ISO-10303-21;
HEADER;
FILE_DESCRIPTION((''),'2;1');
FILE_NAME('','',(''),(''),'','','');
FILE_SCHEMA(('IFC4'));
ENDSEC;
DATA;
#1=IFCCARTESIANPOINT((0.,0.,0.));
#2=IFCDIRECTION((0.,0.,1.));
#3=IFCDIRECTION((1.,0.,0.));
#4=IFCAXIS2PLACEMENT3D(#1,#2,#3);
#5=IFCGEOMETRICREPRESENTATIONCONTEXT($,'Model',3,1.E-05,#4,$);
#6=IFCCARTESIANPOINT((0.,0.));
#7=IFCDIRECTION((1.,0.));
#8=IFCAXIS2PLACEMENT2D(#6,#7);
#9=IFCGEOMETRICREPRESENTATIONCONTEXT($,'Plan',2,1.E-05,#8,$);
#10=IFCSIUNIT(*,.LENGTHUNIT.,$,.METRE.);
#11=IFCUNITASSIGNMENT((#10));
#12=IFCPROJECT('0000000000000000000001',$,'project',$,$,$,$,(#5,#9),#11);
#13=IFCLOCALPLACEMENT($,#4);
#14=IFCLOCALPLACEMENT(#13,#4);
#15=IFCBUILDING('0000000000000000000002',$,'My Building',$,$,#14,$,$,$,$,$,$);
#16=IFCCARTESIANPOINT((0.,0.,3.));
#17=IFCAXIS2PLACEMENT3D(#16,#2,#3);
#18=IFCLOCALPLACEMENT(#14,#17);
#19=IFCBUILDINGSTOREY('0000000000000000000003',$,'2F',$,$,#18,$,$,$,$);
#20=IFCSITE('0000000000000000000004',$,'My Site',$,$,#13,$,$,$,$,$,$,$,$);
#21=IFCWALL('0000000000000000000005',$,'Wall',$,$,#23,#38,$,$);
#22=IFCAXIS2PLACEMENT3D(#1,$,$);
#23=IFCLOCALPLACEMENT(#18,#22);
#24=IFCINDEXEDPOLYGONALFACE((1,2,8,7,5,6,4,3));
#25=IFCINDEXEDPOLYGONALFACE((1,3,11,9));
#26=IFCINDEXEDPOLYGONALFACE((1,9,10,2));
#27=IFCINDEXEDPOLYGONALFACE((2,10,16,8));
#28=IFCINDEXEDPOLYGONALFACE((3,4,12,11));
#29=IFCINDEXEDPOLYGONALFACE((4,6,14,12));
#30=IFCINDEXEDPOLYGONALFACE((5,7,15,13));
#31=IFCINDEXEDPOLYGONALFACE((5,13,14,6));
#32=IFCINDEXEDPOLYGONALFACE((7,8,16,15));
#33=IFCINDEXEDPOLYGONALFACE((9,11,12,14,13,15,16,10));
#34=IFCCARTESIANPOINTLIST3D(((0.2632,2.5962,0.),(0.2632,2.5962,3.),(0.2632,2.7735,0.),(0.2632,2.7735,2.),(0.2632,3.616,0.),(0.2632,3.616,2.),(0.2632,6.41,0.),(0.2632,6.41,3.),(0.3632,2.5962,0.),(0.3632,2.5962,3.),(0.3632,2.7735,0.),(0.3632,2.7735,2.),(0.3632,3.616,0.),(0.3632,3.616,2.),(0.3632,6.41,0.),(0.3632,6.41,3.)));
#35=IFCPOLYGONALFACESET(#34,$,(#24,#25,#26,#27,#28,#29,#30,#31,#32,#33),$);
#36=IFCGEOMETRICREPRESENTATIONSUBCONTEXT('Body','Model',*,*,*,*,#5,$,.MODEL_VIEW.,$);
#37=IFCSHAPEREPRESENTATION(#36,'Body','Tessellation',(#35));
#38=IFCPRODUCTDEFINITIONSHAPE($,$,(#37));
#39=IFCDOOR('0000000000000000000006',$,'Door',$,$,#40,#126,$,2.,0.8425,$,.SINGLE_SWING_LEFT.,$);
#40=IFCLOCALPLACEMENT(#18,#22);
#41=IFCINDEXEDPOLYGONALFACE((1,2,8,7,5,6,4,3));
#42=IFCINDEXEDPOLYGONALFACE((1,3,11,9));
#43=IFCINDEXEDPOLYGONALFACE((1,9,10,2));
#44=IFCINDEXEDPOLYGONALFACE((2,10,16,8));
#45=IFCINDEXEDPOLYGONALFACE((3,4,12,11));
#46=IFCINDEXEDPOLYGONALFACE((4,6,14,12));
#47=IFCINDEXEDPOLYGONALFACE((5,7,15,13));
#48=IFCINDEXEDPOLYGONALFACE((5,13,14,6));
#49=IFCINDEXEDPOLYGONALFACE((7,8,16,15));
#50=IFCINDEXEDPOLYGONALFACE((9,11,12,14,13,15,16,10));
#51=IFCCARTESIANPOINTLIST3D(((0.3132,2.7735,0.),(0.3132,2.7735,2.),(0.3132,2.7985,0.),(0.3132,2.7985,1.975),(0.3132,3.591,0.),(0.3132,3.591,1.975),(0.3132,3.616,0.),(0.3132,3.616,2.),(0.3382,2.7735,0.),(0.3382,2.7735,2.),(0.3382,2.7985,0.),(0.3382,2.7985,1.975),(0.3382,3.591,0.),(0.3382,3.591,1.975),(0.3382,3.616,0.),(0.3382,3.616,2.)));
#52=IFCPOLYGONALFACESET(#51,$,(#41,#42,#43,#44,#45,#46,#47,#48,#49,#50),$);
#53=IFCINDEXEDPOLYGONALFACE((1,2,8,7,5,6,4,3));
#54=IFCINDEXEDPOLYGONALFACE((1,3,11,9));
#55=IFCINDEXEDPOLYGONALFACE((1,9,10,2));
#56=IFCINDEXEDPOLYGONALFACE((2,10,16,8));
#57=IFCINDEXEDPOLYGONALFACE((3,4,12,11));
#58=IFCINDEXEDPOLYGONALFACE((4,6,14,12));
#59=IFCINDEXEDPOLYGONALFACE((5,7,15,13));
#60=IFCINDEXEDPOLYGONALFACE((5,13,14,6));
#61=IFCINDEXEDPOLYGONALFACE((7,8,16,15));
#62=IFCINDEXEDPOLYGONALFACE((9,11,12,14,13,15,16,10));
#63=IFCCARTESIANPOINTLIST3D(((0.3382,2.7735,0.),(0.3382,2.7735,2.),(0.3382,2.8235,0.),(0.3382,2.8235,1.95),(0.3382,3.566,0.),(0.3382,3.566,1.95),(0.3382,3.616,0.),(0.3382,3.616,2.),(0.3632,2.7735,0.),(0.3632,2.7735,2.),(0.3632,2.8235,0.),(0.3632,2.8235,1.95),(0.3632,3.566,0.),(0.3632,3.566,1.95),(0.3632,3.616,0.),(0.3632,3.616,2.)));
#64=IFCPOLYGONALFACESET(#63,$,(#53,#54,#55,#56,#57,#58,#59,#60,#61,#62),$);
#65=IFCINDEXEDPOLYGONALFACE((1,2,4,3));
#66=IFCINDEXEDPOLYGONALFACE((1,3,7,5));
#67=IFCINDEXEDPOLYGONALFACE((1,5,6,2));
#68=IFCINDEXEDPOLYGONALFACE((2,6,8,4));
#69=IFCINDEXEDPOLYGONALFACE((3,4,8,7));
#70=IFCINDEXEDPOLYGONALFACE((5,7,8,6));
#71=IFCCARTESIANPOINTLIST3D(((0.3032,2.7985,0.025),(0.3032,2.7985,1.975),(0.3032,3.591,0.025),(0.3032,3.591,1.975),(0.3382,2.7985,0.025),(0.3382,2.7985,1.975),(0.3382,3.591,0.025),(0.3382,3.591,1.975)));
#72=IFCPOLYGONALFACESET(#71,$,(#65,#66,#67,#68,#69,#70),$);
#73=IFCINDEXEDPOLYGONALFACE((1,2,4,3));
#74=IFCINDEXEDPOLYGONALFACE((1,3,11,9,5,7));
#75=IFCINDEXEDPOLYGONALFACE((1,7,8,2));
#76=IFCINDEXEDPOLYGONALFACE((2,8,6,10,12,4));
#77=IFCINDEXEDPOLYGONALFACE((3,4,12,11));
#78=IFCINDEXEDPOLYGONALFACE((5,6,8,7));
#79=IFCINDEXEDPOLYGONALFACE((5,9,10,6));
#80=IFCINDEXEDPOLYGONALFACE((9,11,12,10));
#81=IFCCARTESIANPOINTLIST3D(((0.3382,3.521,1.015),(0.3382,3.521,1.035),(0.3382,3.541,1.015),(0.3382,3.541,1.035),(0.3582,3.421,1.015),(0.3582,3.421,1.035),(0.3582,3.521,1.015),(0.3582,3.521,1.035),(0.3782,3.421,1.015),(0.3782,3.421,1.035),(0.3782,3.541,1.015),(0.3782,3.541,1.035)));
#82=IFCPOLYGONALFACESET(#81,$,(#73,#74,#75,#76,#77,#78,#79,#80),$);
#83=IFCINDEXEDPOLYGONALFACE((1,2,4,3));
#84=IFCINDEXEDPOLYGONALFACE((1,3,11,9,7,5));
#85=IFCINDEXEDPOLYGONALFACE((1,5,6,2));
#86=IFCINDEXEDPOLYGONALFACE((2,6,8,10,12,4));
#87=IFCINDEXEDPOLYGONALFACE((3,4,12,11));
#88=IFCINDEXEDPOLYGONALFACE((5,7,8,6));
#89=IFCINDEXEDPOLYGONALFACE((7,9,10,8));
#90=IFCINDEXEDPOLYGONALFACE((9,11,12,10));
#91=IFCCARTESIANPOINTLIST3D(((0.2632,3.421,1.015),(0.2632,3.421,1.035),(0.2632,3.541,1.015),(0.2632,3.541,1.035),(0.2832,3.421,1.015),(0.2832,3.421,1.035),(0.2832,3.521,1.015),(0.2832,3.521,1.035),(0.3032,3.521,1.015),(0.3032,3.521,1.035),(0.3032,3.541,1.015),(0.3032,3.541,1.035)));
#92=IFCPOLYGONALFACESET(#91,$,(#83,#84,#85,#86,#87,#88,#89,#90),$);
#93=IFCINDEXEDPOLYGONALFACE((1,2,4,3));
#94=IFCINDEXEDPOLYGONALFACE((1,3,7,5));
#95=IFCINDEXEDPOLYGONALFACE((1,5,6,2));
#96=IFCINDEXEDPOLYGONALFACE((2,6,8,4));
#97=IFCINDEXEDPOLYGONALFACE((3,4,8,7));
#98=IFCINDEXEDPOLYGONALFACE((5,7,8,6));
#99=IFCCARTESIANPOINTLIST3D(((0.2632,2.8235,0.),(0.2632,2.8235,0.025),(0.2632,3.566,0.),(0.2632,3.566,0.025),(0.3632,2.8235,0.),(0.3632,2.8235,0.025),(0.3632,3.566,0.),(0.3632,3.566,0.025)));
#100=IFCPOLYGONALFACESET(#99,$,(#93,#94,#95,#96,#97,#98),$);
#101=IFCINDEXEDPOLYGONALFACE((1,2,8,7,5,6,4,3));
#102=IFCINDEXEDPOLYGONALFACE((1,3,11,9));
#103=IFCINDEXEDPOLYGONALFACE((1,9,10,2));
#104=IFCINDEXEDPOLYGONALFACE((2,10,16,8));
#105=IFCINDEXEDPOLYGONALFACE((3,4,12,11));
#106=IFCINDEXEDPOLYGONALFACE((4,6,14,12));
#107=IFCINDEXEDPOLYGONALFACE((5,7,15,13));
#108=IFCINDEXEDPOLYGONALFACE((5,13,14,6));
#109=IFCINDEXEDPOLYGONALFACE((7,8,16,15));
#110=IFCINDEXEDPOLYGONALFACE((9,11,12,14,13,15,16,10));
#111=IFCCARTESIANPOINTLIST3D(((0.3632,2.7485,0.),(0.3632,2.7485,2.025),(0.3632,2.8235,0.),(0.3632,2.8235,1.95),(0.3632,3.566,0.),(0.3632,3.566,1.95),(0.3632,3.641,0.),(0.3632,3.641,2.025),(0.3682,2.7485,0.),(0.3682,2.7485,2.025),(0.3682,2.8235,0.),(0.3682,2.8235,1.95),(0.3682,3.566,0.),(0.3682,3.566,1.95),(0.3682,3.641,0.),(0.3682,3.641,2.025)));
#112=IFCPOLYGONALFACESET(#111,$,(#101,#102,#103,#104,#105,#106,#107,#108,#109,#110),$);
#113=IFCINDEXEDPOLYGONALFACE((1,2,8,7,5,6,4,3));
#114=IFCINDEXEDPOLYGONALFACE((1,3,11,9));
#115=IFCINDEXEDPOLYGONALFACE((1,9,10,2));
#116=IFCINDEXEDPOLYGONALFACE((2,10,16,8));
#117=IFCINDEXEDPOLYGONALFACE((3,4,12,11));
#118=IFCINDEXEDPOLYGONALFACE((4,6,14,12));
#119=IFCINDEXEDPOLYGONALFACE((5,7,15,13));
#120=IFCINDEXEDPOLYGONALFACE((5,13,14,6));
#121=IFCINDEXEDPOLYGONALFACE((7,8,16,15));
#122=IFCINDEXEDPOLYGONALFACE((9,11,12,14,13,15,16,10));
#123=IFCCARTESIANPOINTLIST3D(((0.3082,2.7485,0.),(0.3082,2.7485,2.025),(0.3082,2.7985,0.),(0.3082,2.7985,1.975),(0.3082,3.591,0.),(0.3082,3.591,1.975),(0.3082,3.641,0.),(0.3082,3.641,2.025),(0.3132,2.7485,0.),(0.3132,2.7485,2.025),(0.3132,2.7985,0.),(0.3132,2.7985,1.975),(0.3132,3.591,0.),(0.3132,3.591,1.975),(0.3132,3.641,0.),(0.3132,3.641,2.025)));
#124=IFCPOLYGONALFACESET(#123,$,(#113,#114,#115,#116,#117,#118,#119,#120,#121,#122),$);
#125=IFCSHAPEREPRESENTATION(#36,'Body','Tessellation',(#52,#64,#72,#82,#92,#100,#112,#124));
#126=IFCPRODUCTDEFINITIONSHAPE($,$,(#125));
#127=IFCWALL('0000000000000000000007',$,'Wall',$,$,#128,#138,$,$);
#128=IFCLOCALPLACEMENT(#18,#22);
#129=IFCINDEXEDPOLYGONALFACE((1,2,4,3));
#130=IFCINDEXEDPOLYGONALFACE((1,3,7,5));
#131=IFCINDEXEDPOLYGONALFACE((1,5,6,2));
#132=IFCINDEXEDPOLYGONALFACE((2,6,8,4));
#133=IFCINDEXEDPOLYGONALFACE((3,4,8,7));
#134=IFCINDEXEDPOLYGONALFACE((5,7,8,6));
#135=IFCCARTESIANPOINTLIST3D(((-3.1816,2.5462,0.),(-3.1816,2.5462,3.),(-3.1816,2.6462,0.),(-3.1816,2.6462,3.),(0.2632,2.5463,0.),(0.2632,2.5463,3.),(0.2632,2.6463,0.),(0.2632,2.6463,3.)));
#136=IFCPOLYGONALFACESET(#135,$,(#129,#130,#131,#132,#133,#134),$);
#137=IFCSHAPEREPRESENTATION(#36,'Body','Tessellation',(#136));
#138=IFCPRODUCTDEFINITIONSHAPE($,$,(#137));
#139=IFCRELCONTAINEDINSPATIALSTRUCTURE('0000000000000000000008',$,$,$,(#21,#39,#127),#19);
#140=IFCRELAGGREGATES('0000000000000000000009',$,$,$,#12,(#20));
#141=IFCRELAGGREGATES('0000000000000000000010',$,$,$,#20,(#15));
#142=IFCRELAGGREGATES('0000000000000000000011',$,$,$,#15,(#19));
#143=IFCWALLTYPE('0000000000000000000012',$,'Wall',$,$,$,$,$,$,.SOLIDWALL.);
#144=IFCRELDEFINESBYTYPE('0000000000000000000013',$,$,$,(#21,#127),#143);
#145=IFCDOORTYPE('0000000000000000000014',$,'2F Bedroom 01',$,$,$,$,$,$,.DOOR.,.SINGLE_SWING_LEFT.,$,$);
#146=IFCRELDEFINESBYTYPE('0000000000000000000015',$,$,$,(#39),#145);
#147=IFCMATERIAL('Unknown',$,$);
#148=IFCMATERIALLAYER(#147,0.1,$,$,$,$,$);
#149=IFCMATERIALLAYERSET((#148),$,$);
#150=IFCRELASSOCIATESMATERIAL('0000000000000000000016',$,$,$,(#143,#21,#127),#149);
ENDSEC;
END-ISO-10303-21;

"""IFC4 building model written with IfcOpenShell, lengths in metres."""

from ifc_helpers import new_model, entity, si_unit, frame, origin_with_axes, origin_2d_with_axis, place, context, subcontext, project, spatial, line, indexed_curve, outline, extrude, shape, source, transform, mapped, material, layer, layer_set, layer_usage, type_object, type_shapes, element, fill, save


model = new_model("IFC4")

# Units and contexts
model_context = context("Model", 3, precision=1e-05, world=origin_with_axes())
plan_context = context("Plan", 2, precision=1e-05, world=origin_2d_with_axis())
body_context_1 = subcontext(model_context, "Body", "Model", "MODEL_VIEW")
body_context_2 = subcontext(plan_context, "Body", "Plan", "PLAN_VIEW")
ifc_project = project(units=[si_unit("LENGTHUNIT", "METRE")], contexts=[model_context, plan_context])

# Site, building, storey
site_placement = place(None, origin_with_axes())
site = spatial("IfcSite", under=ifc_project, at=site_placement, Name="My Site")
building_placement = place(site_placement, origin_with_axes())
building = spatial("IfcBuilding", under=site, at=building_placement, Name="My Building")
storey_placement = place(building_placement, frame((0.0, 0.0, 3.0), z_axis=(0.0, 0.0, 1.0), x_axis=(1.0, 0.0, 0.0)))
storey = spatial("IfcBuildingStorey", under=building, at=storey_placement, Name="2F")

# Shared definitions
ifc_material_1 = material(Name="Unknown")

# Shared definitions
ifc_layer_1 = layer(ifc_material_1, 0.1)
ifc_layer_set_1 = layer_set([ifc_layer_1])
wall_type = type_object("IfcWallType", Name="Wall", PredefinedType="SOLIDWALL", material=ifc_layer_set_1)

# Wall, opening, door
ifc_layer_usage_1 = layer_usage(ifc_layer_set_1, "AXIS2", "POSITIVE", 0.0)
wall_1_placement = place(storey_placement, frame((0.2632, 6.51, 0.0), z_axis=(0.0, 0.0, 1.0), x_axis=(0.0, -1.0, 0.0)))
wall_1 = element("IfcWall", 1, at=wall_1_placement, inside=storey, type_object=wall_type, material=ifc_layer_usage_1, Name="Wall", context=body_context_1, shape_type="SweptSolid", body=[
    extrude(outline(indexed_curve([(0.1, 0.0), (0.1, 0.1), (3.9137, 0.1), (3.9137, 0.0)], segments=[line(1, 2, 3, 4, 1)])), origin_with_axes(), (0.0, 0.0, 1.0), 3.0),
])
shared_shape_1 = source(origin_with_axes(), body_context_1, "Body", "SweptSolid", [
    extrude(outline(indexed_curve([(0.0, 0.0), (0.8425, 0.0), (0.8425, 2.0), (0.0, 2.0)], segments=[line(1, 2, 3, 4, 1)])), frame((0.0, -0.6, 0.0), z_axis=(0.0, -1.0, 0.0), x_axis=(1.0, 0.0, 0.0)), (0.0, 0.0, -1.0), 1.2),
])
opening_1_placement = place(wall_1_placement, frame((3.7364, 0.1, 0.0), z_axis=(0.0, 0.0, 1.0), x_axis=(-1.0, 0.0, 0.0)))
opening_1 = element("IfcOpeningElement", 2, at=opening_1_placement, cuts=wall_1, PredefinedType="OPENING", context=body_context_1, shape_type="MappedRepresentation", body=[
    mapped(shared_shape_1, transform((0.0, 0.0, 0.0), x_axis=(1.0, 0.0, 0.0), y_axis=(0.0, 1.0, 0.0), z_axis=(0.0, 0.0, 1.0), scale=1.0)),
])
door_type_1 = type_object("IfcDoorType", Name="2F Bedroom 01", OperationType="SINGLE_SWING_LEFT", PredefinedType="DOOR")
shared_shape_2 = source(origin_with_axes(), body_context_1, "Body", "SweptSolid", [
    extrude(outline(indexed_curve([(0.0, 0.0), (0.0, 2.0), (0.8425, 2.0), (0.8425, 0.0), (0.8175, 0.0), (0.8175, 1.975), (0.025, 1.975), (0.025, 0.0)], segments=[line(1, 2, 3, 4, 5, 6, 7, 8, 1)])), frame((0.0, 0.025, 0.0), z_axis=(0.0, -1.0, 0.0), x_axis=(1.0, 0.0, 0.0)), (0.0, 0.0, -1.0), 0.025),
    extrude(outline(indexed_curve([(0.0, 0.0), (0.0, 2.0), (0.8425, 2.0), (0.8425, 0.0), (0.7925, 0.0), (0.7925, 1.95), (0.05, 1.95), (0.05, 0.0)], segments=[line(1, 2, 3, 4, 5, 6, 7, 8, 1)])), frame((0.0, 0.0, 0.0), z_axis=(0.0, -1.0, 0.0), x_axis=(1.0, 0.0, 0.0)), (0.0, 0.0, -1.0), 0.025),
    extrude(outline(indexed_curve([(0.0, 0.0), (0.7925, 0.0), (0.7925, 0.035), (0.0, 0.035)], segments=[line(1, 2, 3, 4, 1)])), frame((0.025, 0.025, 0.025), z_axis=(0.0, 0.0, 1.0), x_axis=(1.0, 0.0, 0.0)), (0.0, 0.0, 1.0), 1.95),
    extrude(outline(indexed_curve([(0.0, 0.0), (0.0, -0.04), (-0.12, -0.04), (-0.12, -0.02), (-0.02, -0.02), (-0.02, 0.0)], segments=[line(1, 2, 3, 4, 5, 6, 1)])), frame((0.7675, 0.025, 1.015), z_axis=(0.0, 0.0, 1.0), x_axis=(1.0, 0.0, 0.0)), (0.0, 0.0, 1.0), 0.02),
    extrude(outline(indexed_curve([(0.0, 0.0), (0.0, 0.04), (-0.12, 0.04), (-0.12, 0.02), (-0.02, 0.02), (-0.02, 0.0)], segments=[line(1, 2, 3, 4, 5, 6, 1)])), frame((0.7675, 0.06, 1.015), z_axis=(0.0, 0.0, 1.0), x_axis=(1.0, 0.0, 0.0)), (0.0, 0.0, 1.0), 0.02),
    extrude(outline(indexed_curve([(0.0, 0.0), (0.7425, 0.0), (0.7425, 0.1), (0.0, 0.1)], segments=[line(1, 2, 3, 4, 1)])), frame((0.05, 0.0, 0.0), z_axis=(0.0, 0.0, 1.0), x_axis=(1.0, 0.0, 0.0)), (0.0, 0.0, 1.0), 0.025),
    extrude(outline(indexed_curve([(0.0, 0.0), (0.0, 2.025), (0.8925, 2.025), (0.8925, 0.0), (0.8175, 0.0), (0.8175, 1.95), (0.075, 1.95), (0.075, 0.0)], segments=[line(1, 2, 3, 4, 5, 6, 7, 8, 1)])), frame((-0.025, -0.005, 0.0), z_axis=(0.0, -1.0, 0.0), x_axis=(1.0, 0.0, 0.0)), (0.0, 0.0, -1.0), 0.005),
    extrude(outline(indexed_curve([(0.0, 0.0), (0.0, 2.025), (0.8925, 2.025), (0.8925, 0.0), (0.8425, 0.0), (0.8425, 1.975), (0.05, 1.975), (0.05, 0.0)], segments=[line(1, 2, 3, 4, 5, 6, 7, 8, 1)])), frame((-0.025, 0.05, 0.0), z_axis=(0.0, -1.0, 0.0), x_axis=(1.0, 0.0, 0.0)), (0.0, 0.0, -1.0), 0.005),
])
shared_shape_3 = source(origin_with_axes(), body_context_2, "Body", "Curve2D", [
    entity("IfcIndexedPolyCurve", entity("IfcCartesianPointList2D", [[0.0, 0.0], [0.0, 0.05], [0.025, 0.05], [0.025, 0.025], [0.05, 0.025], [0.05, 0.0]]), [entity("IfcLineIndex", [1, 2, 3, 4, 5, 6, 1])]),
    entity("IfcIndexedPolyCurve", entity("IfcCartesianPointList2D", [[0.8425, 0.0], [0.8425, 0.05], [0.8175, 0.05], [0.8175, 0.025], [0.7925, 0.025], [0.7925, 0.0]]), [entity("IfcLineIndex", [1, 2, 3, 4, 5, 6, 1])]),
    entity("IfcTrimmedCurve", entity("IfcEllipse", entity("IfcAxis2Placement2D", entity("IfcCartesianPoint", [0.06, 0.05]), entity("IfcDirection", [1.0, 0.0])), 0.7575, 0.7925), [entity("IfcCartesianPoint", [0.8175, 0.05])], [entity("IfcCartesianPoint", [0.06, 0.8425])], True, "CARTESIAN"),
    entity("IfcIndexedPolyCurve", entity("IfcCartesianPointList2D", [[0.025, 0.05], [0.06, 0.05], [0.06, 0.8425], [0.025, 0.8425]]), [entity("IfcLineIndex", [1, 2, 3, 4, 1])]),
])
type_shapes(door_type_1, [shared_shape_2, shared_shape_3])
door_1_placement = place(opening_1_placement, frame((0.0, 0.0, 0.0), z_axis=(0.0, 0.0, 1.0), x_axis=(1.0, 0.0, 0.0)))
door_1 = element("IfcDoor", 3, at=door_1_placement, inside=storey, type_object=door_type_1, Name="Door", OperationType="SINGLE_SWING_LEFT", OverallHeight=2.0, OverallWidth=0.8425, shapes=[
    shape(body_context_1, "Body", "MappedRepresentation", [mapped(shared_shape_2, transform((0.0, 0.0, 0.0), x_axis=(1.0, 0.0, 0.0), y_axis=(0.0, 1.0, 0.0), z_axis=(0.0, 0.0, 1.0), scale=1.0))]),
    shape(body_context_2, "Body", "MappedRepresentation", [mapped(shared_shape_3, transform((0.0, 0.0, 0.0), x_axis=(1.0, 0.0, 0.0), y_axis=(0.0, 1.0, 0.0), z_axis=(0.0, 0.0, 1.0), scale=1.0))]),
])
fill(opening_1, door_1)

# Wall
ifc_layer_usage_2 = layer_usage(ifc_layer_set_1, "AXIS2", "POSITIVE", 0.0)
wall_2_placement = place(storey_placement, frame((0.2632, 2.6463, 0.0), z_axis=(0.0, 0.0, 1.0), x_axis=(-1.0, 0.0, 0.0)))
element("IfcWall", 4, at=wall_2_placement, inside=storey, type_object=wall_type, material=ifc_layer_usage_2, Name="Wall", context=body_context_1, shape_type="SweptSolid", body=[
    extrude(outline(indexed_curve([(0.0, 0.0), (0.0, 0.1), (3.4448, 0.1), (3.4448, 0.0)], segments=[line(1, 2, 3, 4, 1)])), origin_with_axes(), (0.0, 0.0, 1.0), 3.0),
])

save(model, "model.ifc")
